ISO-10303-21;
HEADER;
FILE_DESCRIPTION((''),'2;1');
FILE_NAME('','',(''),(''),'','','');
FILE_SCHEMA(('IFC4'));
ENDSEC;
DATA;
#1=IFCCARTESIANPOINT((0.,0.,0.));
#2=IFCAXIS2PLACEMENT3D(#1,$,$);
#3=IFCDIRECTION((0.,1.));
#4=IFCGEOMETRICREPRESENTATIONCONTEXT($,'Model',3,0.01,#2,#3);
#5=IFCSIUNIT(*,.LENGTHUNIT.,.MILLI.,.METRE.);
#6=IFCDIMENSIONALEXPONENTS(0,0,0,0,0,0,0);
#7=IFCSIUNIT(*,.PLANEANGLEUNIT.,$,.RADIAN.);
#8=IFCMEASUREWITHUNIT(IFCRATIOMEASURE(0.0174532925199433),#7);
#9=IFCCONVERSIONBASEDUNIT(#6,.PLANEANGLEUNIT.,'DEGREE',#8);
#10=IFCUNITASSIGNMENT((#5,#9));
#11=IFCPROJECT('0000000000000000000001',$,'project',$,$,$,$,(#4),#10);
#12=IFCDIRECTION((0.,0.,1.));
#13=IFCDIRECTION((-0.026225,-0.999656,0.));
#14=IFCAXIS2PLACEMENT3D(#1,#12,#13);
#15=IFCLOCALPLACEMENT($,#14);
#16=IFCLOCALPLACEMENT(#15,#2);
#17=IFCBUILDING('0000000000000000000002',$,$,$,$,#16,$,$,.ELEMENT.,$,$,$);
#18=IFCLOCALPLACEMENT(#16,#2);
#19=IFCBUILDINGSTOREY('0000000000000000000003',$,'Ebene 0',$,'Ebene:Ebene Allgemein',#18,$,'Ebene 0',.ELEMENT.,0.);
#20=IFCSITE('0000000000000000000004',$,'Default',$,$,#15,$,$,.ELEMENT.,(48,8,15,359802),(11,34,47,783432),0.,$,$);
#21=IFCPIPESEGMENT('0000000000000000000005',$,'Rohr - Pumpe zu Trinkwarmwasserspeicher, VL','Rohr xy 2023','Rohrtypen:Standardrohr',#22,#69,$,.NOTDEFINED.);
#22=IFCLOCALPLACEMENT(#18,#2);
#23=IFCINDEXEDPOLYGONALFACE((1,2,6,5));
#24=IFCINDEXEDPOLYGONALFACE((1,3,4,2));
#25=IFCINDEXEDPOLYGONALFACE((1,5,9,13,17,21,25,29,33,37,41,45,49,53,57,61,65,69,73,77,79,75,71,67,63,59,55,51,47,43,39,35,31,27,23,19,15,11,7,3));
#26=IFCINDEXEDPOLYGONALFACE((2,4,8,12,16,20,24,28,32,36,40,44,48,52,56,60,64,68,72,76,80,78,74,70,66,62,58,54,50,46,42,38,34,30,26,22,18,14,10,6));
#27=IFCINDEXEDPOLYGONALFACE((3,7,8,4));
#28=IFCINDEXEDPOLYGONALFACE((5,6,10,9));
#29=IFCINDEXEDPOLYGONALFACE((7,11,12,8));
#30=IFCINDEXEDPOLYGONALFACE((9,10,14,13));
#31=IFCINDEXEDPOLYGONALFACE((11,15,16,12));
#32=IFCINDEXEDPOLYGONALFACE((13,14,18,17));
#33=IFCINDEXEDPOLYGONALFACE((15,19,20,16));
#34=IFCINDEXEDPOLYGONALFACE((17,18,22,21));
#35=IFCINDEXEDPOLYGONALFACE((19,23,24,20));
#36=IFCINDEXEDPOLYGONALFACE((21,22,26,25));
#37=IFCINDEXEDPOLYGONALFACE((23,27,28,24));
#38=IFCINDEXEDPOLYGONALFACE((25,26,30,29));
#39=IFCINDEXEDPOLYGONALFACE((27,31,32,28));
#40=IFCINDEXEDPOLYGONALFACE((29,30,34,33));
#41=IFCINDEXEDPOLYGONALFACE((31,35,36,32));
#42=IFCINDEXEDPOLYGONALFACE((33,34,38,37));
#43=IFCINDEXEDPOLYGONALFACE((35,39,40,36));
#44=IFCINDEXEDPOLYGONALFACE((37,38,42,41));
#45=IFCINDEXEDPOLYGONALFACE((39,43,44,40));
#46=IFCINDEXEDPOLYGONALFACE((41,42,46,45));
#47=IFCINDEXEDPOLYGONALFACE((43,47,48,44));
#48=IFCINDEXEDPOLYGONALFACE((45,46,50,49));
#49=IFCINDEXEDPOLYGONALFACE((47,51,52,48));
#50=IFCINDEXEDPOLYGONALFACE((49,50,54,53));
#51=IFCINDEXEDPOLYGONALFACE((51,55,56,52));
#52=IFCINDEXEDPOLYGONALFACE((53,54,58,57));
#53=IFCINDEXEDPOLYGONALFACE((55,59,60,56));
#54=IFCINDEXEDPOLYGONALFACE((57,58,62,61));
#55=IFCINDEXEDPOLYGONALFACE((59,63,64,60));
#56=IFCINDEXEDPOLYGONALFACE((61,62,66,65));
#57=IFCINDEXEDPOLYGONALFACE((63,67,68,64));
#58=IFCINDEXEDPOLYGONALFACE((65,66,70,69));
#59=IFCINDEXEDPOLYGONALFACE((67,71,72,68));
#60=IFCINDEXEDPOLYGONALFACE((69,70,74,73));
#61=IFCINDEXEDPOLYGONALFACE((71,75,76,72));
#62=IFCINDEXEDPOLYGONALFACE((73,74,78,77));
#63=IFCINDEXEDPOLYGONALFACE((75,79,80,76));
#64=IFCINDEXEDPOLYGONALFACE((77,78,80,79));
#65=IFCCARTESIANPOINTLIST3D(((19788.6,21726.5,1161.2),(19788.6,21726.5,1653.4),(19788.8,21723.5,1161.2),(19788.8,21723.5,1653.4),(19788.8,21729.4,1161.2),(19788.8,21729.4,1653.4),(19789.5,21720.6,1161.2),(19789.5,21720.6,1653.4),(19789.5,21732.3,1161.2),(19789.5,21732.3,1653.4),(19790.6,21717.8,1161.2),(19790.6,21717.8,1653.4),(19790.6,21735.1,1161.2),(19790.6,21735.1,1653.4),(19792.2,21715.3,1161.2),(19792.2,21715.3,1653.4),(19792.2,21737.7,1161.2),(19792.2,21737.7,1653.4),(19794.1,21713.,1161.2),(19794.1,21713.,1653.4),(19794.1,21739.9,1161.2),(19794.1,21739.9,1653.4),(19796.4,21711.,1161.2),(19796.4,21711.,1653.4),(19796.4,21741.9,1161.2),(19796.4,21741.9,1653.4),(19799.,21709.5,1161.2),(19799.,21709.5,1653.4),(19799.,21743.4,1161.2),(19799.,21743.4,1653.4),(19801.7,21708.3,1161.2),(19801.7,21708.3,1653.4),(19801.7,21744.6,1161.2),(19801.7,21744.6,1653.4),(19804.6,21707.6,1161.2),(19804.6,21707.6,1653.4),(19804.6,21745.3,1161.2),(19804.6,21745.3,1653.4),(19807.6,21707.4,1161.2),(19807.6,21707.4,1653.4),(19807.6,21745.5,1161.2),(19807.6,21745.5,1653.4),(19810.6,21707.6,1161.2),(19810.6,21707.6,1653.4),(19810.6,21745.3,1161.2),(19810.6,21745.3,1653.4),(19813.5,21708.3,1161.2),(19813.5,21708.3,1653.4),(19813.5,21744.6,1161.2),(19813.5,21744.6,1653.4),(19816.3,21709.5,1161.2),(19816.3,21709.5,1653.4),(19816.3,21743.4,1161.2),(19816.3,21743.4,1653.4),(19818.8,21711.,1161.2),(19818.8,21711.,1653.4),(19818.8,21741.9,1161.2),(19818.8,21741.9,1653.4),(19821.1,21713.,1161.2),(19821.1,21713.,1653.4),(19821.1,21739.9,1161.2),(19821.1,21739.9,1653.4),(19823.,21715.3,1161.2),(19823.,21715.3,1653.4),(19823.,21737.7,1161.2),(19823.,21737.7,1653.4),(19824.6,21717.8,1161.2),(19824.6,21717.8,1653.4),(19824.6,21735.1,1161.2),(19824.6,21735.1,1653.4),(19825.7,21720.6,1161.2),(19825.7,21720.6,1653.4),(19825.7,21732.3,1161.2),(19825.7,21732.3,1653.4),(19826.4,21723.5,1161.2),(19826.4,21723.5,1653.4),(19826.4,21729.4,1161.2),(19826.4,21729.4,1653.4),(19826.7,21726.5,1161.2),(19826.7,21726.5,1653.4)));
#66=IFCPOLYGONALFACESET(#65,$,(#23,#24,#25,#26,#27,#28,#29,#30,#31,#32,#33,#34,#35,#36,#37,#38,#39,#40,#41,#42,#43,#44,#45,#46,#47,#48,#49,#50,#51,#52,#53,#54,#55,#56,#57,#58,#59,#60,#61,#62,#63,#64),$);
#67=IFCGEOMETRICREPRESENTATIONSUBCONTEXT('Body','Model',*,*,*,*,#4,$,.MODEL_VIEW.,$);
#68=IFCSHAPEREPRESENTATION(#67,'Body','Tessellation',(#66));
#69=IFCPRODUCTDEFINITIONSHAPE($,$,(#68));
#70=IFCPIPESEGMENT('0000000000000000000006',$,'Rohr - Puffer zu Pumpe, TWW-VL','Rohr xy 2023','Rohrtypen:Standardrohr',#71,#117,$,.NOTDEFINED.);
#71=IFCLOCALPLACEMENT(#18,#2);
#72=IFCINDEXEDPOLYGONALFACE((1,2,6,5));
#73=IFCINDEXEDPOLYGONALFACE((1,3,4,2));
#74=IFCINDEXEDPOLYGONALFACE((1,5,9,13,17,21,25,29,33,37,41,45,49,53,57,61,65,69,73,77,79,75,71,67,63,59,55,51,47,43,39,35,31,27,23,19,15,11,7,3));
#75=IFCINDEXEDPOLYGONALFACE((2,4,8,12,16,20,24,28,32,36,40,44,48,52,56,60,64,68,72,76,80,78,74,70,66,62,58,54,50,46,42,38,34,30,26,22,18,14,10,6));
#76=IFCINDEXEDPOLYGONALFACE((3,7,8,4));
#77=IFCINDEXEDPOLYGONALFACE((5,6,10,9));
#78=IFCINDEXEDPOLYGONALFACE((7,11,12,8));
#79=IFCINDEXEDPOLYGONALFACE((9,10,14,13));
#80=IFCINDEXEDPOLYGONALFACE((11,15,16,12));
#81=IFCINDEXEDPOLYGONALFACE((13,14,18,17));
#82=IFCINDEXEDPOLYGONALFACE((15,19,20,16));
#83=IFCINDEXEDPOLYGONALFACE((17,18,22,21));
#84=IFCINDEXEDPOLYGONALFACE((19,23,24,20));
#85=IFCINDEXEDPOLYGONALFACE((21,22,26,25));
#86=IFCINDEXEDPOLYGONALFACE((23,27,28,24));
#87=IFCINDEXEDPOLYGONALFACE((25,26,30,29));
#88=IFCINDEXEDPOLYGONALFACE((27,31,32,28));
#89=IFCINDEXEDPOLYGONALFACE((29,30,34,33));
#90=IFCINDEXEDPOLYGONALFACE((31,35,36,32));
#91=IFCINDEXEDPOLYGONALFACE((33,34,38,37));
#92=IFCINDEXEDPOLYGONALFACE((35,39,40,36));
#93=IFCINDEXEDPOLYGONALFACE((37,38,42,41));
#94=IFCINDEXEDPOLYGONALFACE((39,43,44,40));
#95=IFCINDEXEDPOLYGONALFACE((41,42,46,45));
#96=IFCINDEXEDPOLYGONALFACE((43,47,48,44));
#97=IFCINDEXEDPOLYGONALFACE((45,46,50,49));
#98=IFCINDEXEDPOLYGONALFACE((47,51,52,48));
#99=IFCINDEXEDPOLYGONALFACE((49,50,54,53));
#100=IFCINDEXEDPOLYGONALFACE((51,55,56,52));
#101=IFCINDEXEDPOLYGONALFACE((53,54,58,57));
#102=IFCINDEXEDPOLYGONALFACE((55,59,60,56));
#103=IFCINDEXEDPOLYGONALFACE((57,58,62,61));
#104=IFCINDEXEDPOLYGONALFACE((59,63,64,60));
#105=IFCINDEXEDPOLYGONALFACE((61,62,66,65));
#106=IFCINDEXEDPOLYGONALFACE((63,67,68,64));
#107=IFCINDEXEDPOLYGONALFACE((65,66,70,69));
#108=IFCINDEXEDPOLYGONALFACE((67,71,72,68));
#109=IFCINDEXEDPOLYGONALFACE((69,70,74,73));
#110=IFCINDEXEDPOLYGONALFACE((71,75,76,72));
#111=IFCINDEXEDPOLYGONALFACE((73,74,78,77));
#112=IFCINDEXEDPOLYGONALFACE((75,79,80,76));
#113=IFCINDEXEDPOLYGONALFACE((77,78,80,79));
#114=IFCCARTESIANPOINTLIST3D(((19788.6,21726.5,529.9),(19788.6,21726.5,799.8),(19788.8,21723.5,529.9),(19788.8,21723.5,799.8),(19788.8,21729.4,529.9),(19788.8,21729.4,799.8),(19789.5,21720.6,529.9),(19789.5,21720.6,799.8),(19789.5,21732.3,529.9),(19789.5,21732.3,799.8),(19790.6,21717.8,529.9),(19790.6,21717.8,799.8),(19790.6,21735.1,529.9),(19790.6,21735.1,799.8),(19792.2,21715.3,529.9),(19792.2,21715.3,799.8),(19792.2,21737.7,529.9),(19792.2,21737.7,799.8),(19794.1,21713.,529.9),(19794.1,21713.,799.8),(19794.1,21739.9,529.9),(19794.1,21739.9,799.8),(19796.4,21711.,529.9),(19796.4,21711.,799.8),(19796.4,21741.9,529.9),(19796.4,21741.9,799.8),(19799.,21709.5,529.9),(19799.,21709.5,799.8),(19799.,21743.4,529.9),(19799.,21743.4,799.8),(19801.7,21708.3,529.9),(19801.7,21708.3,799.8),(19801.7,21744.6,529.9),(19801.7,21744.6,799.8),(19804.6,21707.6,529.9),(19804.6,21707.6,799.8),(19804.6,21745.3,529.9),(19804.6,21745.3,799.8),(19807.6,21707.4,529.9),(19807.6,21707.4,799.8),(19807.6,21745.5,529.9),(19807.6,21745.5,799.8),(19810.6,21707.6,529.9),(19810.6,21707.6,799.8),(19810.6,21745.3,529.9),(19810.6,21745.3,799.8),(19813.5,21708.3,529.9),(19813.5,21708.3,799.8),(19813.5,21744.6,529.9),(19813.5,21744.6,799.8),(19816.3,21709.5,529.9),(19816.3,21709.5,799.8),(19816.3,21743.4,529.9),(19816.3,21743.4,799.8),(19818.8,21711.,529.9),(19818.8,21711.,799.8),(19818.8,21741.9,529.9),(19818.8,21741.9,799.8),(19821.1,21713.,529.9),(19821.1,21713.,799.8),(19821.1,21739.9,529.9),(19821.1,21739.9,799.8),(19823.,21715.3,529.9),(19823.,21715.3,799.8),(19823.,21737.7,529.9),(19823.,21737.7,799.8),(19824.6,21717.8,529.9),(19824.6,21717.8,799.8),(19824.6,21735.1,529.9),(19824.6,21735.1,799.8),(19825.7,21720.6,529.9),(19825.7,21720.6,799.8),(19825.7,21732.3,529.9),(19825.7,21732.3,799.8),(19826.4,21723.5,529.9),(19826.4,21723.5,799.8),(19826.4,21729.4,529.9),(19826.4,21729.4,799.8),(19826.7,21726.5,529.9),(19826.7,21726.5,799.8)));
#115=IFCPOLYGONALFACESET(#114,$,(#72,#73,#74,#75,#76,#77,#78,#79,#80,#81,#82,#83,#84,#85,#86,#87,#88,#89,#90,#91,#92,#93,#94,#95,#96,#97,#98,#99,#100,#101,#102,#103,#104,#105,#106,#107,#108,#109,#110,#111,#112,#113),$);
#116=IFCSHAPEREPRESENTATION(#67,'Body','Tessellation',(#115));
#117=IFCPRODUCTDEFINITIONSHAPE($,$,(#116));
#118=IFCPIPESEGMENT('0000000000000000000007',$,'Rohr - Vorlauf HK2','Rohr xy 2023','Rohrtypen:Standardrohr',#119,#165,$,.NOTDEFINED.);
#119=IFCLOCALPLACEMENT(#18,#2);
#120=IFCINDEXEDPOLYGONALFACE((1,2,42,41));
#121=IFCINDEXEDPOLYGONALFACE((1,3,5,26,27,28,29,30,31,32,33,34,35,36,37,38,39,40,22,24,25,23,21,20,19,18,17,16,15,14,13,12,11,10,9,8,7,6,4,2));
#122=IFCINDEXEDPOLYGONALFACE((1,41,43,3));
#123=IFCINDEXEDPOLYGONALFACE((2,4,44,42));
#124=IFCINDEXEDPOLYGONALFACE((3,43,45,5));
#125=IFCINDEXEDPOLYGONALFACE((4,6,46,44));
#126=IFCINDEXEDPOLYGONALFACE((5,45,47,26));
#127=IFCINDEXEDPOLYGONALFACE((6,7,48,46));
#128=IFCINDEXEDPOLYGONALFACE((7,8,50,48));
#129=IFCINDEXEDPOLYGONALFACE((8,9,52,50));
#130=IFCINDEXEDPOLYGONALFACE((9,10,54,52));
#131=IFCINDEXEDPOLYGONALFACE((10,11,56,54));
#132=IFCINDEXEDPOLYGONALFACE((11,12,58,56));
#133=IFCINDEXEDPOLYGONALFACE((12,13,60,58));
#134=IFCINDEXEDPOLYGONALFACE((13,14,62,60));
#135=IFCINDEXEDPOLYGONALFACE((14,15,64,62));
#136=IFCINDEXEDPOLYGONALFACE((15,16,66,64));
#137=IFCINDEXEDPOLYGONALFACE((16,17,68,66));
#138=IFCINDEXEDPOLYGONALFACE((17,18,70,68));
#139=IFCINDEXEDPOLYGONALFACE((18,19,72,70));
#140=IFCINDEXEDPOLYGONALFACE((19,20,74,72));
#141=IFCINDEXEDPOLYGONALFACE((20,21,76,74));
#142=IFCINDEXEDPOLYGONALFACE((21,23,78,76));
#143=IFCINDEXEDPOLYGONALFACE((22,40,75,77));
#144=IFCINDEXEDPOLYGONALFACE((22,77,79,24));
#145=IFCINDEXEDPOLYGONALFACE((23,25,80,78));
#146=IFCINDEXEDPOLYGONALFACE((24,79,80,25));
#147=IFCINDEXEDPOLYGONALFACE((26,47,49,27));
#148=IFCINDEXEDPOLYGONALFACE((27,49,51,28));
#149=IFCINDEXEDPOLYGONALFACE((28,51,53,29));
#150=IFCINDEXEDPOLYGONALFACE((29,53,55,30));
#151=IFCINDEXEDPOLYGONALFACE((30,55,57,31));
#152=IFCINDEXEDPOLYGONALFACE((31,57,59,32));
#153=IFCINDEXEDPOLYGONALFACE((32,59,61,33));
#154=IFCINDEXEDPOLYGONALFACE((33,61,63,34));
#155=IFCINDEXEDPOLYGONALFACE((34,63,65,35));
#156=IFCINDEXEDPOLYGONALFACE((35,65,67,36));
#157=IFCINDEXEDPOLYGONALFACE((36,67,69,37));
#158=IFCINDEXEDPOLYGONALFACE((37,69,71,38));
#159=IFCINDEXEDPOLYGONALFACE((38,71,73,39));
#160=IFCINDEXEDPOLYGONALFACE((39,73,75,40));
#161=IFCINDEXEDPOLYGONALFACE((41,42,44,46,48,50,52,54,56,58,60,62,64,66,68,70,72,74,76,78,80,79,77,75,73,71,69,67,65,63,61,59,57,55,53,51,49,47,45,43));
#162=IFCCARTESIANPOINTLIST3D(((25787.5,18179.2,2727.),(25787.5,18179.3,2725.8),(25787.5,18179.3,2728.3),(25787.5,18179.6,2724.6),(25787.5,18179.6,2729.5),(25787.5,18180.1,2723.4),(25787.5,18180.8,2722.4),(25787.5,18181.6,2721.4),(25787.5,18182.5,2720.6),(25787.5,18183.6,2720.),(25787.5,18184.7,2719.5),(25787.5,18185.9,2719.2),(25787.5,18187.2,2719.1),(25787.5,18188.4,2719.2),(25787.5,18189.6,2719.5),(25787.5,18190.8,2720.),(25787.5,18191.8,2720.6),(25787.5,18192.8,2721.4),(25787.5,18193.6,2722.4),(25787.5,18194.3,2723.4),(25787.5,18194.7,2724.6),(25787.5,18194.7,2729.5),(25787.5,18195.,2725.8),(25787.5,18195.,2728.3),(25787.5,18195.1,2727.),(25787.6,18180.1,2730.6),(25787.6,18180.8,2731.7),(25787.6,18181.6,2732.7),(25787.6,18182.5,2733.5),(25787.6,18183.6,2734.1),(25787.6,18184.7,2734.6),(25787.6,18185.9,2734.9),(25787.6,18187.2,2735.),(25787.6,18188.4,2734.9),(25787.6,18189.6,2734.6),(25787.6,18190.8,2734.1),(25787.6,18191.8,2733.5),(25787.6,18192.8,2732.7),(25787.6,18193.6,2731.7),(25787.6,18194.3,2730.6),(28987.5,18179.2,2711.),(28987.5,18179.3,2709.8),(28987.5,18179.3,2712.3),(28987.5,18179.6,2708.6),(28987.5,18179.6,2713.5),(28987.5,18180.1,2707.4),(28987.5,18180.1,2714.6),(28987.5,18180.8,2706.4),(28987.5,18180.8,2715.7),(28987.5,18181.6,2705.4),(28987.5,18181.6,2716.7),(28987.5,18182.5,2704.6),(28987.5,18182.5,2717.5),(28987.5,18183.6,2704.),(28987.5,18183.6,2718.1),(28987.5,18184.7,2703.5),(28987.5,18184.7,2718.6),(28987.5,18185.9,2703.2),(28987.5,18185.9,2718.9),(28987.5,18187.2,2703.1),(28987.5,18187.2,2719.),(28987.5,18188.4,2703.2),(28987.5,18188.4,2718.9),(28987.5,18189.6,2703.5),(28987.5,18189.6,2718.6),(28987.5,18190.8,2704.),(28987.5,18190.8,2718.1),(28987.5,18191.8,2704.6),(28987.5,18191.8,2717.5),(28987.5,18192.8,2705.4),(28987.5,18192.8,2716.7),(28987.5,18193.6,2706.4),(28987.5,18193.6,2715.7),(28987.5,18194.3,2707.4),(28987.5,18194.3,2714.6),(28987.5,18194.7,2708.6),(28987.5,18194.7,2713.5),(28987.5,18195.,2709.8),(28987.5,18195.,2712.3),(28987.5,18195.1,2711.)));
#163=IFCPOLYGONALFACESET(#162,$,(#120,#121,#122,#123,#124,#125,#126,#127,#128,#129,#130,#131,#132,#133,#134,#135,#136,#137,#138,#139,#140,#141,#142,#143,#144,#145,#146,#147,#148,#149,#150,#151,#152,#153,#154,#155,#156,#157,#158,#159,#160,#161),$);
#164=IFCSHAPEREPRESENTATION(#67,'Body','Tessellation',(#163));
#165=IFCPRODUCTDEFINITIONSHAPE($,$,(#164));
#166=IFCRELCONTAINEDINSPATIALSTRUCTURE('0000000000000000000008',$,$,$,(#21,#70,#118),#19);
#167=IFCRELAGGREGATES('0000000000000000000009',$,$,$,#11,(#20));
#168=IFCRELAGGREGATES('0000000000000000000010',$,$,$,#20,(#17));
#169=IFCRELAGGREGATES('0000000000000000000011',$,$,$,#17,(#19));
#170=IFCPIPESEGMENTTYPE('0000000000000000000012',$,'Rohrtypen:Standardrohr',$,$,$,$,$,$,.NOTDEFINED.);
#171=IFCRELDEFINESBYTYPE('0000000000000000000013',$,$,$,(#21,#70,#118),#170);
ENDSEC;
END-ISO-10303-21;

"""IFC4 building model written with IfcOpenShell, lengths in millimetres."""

from ifc_helpers import new_model, entity, si_unit, converted_unit, direction, frame, origin, place, context, subcontext, project, spatial, indexed_curve, outline, extrude, type_object, element, save


model = new_model("IFC4")

# Units and contexts
model_context = context("Model", 3, precision=0.01, world=origin(), true_north=direction((0.0, 1.0)))
body_context = subcontext(model_context, "Body", "Model", "MODEL_VIEW")
ifc_project = project(units=[si_unit("LENGTHUNIT", "METRE", prefix="MILLI"), converted_unit("PLANEANGLEUNIT", "DEGREE", entity("IfcRatioMeasure", 0.0174532925199433), si_unit("PLANEANGLEUNIT", "RADIAN"), dimensions=[0, 0, 0, 0, 0, 0, 0])], contexts=[model_context])

# Site, building, storey
site_placement = place(None, frame((0.0, 0.0, 0.0), z_axis=(0.0, 0.0, 1.0), x_axis=(-0.026225, -0.999656, 0.0)))
site = spatial("IfcSite", under=ifc_project, at=site_placement, Name="Default", CompositionType="ELEMENT", RefLatitude=(48, 8, 15, 359802), RefLongitude=(11, 34, 47, 783432), RefElevation=0.0)
building_placement = place(site_placement, origin())
building = spatial("IfcBuilding", under=site, at=building_placement, CompositionType="ELEMENT")
storey_placement = place(building_placement, origin())
storey = spatial("IfcBuildingStorey", under=building, at=storey_placement, Name="Ebene 0", ObjectType="Ebene:Ebene Allgemein", LongName="Ebene 0", CompositionType="ELEMENT", Elevation=0.0)

# Pipe segments
pipe_segment_type = type_object("IfcPipeSegmentType", Name="Rohrtypen:Standardrohr", PredefinedType="NOTDEFINED")
pipe_segment_1_placement = place(storey_placement, origin())
element("IfcPipeSegment", 1, at=pipe_segment_1_placement, inside=storey, type_object=pipe_segment_type, Name="Rohr - Pumpe zu Trinkwarmwasserspeicher, VL", Description="Rohr xy 2023", ObjectType="Rohrtypen:Standardrohr", PredefinedType="NOTDEFINED", context=body_context, shape_type="SweptSolid", body=[
    extrude(outline(indexed_curve([(19.1, 0.0), (18.8, 3.0), (18.1, 5.9), (17.0, 8.6), (15.4, 11.2), (13.5, 13.5), (11.2, 15.4), (8.6, 17.0), (5.9, 18.1), (3.0, 18.8), (0.0, 19.0), (-3.0, 18.8), (-5.9, 18.1), (-8.6, 17.0), (-11.2, 15.4), (-13.5, 13.5), (-15.4, 11.2), (-17.0, 8.6), (-18.1, 5.9), (-18.8, 3.0), (-19.1, 0.0), (-18.8, -3.0), (-18.1, -5.9), (-17.0, -8.6), (-15.4, -11.2), (-13.5, -13.5), (-11.2, -15.4), (-8.6, -17.0), (-5.9, -18.1), (-3.0, -18.8), (0.0, -19.0), (3.0, -18.8), (5.9, -18.1), (8.6, -17.0), (11.2, -15.4), (13.5, -13.5), (15.4, -11.2), (17.0, -8.6), (18.1, -5.9), (18.8, -3.0), (19.1, 0.0)], self_intersect=False)), frame((19807.6, 21726.5, 1161.2), z_axis=(0.000002, 0.000002, 1.0), x_axis=(-1.0, 0.0, 0.000002)), (0.0, 0.0, 1.0), 492.1),
])
pipe_segment_2_placement = place(storey_placement, origin())
element("IfcPipeSegment", 2, at=pipe_segment_2_placement, inside=storey, type_object=pipe_segment_type, Name="Rohr - Puffer zu Pumpe, TWW-VL", Description="Rohr xy 2023", ObjectType="Rohrtypen:Standardrohr", PredefinedType="NOTDEFINED", context=body_context, shape_type="SweptSolid", body=[
    extrude(outline(indexed_curve([(19.1, 0.0), (18.8, 3.0), (18.1, 5.9), (17.0, 8.6), (15.4, 11.2), (13.5, 13.5), (11.2, 15.4), (8.6, 17.0), (5.9, 18.1), (3.0, 18.8), (0.0, 19.0), (-3.0, 18.8), (-5.9, 18.1), (-8.6, 17.0), (-11.2, 15.4), (-13.5, 13.5), (-15.4, 11.2), (-17.0, 8.6), (-18.1, 5.9), (-18.8, 3.0), (-19.1, 0.0), (-18.8, -3.0), (-18.1, -5.9), (-17.0, -8.6), (-15.4, -11.2), (-13.5, -13.5), (-11.2, -15.4), (-8.6, -17.0), (-5.9, -18.1), (-3.0, -18.8), (0.0, -19.0), (3.0, -18.8), (5.9, -18.1), (8.6, -17.0), (11.2, -15.4), (13.5, -13.5), (15.4, -11.2), (17.0, -8.6), (18.1, -5.9), (18.8, -3.0), (19.1, 0.0)], self_intersect=False)), frame((19807.6, 21726.5, 529.9), z_axis=(0.000002, 0.000002, 1.0), x_axis=(-1.0, 0.0, 0.000002)), (0.0, 0.0, 1.0), 269.9),
])
pipe_segment_3_placement = place(storey_placement, origin())
element("IfcPipeSegment", 3, at=pipe_segment_3_placement, inside=storey, type_object=pipe_segment_type, Name="Rohr - Vorlauf HK2", Description="Rohr xy 2023", ObjectType="Rohrtypen:Standardrohr", PredefinedType="NOTDEFINED", context=body_context, shape_type="SweptSolid", body=[
    extrude(outline(indexed_curve([(7.9, 0.0), (7.8, 1.2), (7.6, 2.5), (7.1, 3.6), (6.4, 4.7), (5.6, 5.6), (4.7, 6.4), (3.6, 7.1), (2.5, 7.6), (1.2, 7.8), (0.0, 7.9), (-1.2, 7.8), (-2.5, 7.6), (-3.6, 7.1), (-4.7, 6.4), (-5.6, 5.6), (-6.4, 4.7), (-7.1, 3.6), (-7.6, 2.5), (-7.8, 1.2), (-7.9, 0.0), (-7.8, -1.2), (-7.6, -2.5), (-7.1, -3.6), (-6.4, -4.7), (-5.6, -5.6), (-4.7, -6.4), (-3.6, -7.1), (-2.5, -7.6), (-1.2, -7.8), (0.0, -7.9), (1.2, -7.8), (2.5, -7.6), (3.6, -7.1), (4.7, -6.4), (5.6, -5.6), (6.4, -4.7), (7.1, -3.6), (7.6, -2.5), (7.8, -1.2), (7.9, 0.0)], self_intersect=False)), frame((28987.5, 18187.2, 2711.0), z_axis=(-0.999988, 0.0, 0.005), x_axis=(0.0, 1.0, 0.0)), (0.0, 0.0, 1.0), 3200.0),
])

save(model, "model.ifc")
